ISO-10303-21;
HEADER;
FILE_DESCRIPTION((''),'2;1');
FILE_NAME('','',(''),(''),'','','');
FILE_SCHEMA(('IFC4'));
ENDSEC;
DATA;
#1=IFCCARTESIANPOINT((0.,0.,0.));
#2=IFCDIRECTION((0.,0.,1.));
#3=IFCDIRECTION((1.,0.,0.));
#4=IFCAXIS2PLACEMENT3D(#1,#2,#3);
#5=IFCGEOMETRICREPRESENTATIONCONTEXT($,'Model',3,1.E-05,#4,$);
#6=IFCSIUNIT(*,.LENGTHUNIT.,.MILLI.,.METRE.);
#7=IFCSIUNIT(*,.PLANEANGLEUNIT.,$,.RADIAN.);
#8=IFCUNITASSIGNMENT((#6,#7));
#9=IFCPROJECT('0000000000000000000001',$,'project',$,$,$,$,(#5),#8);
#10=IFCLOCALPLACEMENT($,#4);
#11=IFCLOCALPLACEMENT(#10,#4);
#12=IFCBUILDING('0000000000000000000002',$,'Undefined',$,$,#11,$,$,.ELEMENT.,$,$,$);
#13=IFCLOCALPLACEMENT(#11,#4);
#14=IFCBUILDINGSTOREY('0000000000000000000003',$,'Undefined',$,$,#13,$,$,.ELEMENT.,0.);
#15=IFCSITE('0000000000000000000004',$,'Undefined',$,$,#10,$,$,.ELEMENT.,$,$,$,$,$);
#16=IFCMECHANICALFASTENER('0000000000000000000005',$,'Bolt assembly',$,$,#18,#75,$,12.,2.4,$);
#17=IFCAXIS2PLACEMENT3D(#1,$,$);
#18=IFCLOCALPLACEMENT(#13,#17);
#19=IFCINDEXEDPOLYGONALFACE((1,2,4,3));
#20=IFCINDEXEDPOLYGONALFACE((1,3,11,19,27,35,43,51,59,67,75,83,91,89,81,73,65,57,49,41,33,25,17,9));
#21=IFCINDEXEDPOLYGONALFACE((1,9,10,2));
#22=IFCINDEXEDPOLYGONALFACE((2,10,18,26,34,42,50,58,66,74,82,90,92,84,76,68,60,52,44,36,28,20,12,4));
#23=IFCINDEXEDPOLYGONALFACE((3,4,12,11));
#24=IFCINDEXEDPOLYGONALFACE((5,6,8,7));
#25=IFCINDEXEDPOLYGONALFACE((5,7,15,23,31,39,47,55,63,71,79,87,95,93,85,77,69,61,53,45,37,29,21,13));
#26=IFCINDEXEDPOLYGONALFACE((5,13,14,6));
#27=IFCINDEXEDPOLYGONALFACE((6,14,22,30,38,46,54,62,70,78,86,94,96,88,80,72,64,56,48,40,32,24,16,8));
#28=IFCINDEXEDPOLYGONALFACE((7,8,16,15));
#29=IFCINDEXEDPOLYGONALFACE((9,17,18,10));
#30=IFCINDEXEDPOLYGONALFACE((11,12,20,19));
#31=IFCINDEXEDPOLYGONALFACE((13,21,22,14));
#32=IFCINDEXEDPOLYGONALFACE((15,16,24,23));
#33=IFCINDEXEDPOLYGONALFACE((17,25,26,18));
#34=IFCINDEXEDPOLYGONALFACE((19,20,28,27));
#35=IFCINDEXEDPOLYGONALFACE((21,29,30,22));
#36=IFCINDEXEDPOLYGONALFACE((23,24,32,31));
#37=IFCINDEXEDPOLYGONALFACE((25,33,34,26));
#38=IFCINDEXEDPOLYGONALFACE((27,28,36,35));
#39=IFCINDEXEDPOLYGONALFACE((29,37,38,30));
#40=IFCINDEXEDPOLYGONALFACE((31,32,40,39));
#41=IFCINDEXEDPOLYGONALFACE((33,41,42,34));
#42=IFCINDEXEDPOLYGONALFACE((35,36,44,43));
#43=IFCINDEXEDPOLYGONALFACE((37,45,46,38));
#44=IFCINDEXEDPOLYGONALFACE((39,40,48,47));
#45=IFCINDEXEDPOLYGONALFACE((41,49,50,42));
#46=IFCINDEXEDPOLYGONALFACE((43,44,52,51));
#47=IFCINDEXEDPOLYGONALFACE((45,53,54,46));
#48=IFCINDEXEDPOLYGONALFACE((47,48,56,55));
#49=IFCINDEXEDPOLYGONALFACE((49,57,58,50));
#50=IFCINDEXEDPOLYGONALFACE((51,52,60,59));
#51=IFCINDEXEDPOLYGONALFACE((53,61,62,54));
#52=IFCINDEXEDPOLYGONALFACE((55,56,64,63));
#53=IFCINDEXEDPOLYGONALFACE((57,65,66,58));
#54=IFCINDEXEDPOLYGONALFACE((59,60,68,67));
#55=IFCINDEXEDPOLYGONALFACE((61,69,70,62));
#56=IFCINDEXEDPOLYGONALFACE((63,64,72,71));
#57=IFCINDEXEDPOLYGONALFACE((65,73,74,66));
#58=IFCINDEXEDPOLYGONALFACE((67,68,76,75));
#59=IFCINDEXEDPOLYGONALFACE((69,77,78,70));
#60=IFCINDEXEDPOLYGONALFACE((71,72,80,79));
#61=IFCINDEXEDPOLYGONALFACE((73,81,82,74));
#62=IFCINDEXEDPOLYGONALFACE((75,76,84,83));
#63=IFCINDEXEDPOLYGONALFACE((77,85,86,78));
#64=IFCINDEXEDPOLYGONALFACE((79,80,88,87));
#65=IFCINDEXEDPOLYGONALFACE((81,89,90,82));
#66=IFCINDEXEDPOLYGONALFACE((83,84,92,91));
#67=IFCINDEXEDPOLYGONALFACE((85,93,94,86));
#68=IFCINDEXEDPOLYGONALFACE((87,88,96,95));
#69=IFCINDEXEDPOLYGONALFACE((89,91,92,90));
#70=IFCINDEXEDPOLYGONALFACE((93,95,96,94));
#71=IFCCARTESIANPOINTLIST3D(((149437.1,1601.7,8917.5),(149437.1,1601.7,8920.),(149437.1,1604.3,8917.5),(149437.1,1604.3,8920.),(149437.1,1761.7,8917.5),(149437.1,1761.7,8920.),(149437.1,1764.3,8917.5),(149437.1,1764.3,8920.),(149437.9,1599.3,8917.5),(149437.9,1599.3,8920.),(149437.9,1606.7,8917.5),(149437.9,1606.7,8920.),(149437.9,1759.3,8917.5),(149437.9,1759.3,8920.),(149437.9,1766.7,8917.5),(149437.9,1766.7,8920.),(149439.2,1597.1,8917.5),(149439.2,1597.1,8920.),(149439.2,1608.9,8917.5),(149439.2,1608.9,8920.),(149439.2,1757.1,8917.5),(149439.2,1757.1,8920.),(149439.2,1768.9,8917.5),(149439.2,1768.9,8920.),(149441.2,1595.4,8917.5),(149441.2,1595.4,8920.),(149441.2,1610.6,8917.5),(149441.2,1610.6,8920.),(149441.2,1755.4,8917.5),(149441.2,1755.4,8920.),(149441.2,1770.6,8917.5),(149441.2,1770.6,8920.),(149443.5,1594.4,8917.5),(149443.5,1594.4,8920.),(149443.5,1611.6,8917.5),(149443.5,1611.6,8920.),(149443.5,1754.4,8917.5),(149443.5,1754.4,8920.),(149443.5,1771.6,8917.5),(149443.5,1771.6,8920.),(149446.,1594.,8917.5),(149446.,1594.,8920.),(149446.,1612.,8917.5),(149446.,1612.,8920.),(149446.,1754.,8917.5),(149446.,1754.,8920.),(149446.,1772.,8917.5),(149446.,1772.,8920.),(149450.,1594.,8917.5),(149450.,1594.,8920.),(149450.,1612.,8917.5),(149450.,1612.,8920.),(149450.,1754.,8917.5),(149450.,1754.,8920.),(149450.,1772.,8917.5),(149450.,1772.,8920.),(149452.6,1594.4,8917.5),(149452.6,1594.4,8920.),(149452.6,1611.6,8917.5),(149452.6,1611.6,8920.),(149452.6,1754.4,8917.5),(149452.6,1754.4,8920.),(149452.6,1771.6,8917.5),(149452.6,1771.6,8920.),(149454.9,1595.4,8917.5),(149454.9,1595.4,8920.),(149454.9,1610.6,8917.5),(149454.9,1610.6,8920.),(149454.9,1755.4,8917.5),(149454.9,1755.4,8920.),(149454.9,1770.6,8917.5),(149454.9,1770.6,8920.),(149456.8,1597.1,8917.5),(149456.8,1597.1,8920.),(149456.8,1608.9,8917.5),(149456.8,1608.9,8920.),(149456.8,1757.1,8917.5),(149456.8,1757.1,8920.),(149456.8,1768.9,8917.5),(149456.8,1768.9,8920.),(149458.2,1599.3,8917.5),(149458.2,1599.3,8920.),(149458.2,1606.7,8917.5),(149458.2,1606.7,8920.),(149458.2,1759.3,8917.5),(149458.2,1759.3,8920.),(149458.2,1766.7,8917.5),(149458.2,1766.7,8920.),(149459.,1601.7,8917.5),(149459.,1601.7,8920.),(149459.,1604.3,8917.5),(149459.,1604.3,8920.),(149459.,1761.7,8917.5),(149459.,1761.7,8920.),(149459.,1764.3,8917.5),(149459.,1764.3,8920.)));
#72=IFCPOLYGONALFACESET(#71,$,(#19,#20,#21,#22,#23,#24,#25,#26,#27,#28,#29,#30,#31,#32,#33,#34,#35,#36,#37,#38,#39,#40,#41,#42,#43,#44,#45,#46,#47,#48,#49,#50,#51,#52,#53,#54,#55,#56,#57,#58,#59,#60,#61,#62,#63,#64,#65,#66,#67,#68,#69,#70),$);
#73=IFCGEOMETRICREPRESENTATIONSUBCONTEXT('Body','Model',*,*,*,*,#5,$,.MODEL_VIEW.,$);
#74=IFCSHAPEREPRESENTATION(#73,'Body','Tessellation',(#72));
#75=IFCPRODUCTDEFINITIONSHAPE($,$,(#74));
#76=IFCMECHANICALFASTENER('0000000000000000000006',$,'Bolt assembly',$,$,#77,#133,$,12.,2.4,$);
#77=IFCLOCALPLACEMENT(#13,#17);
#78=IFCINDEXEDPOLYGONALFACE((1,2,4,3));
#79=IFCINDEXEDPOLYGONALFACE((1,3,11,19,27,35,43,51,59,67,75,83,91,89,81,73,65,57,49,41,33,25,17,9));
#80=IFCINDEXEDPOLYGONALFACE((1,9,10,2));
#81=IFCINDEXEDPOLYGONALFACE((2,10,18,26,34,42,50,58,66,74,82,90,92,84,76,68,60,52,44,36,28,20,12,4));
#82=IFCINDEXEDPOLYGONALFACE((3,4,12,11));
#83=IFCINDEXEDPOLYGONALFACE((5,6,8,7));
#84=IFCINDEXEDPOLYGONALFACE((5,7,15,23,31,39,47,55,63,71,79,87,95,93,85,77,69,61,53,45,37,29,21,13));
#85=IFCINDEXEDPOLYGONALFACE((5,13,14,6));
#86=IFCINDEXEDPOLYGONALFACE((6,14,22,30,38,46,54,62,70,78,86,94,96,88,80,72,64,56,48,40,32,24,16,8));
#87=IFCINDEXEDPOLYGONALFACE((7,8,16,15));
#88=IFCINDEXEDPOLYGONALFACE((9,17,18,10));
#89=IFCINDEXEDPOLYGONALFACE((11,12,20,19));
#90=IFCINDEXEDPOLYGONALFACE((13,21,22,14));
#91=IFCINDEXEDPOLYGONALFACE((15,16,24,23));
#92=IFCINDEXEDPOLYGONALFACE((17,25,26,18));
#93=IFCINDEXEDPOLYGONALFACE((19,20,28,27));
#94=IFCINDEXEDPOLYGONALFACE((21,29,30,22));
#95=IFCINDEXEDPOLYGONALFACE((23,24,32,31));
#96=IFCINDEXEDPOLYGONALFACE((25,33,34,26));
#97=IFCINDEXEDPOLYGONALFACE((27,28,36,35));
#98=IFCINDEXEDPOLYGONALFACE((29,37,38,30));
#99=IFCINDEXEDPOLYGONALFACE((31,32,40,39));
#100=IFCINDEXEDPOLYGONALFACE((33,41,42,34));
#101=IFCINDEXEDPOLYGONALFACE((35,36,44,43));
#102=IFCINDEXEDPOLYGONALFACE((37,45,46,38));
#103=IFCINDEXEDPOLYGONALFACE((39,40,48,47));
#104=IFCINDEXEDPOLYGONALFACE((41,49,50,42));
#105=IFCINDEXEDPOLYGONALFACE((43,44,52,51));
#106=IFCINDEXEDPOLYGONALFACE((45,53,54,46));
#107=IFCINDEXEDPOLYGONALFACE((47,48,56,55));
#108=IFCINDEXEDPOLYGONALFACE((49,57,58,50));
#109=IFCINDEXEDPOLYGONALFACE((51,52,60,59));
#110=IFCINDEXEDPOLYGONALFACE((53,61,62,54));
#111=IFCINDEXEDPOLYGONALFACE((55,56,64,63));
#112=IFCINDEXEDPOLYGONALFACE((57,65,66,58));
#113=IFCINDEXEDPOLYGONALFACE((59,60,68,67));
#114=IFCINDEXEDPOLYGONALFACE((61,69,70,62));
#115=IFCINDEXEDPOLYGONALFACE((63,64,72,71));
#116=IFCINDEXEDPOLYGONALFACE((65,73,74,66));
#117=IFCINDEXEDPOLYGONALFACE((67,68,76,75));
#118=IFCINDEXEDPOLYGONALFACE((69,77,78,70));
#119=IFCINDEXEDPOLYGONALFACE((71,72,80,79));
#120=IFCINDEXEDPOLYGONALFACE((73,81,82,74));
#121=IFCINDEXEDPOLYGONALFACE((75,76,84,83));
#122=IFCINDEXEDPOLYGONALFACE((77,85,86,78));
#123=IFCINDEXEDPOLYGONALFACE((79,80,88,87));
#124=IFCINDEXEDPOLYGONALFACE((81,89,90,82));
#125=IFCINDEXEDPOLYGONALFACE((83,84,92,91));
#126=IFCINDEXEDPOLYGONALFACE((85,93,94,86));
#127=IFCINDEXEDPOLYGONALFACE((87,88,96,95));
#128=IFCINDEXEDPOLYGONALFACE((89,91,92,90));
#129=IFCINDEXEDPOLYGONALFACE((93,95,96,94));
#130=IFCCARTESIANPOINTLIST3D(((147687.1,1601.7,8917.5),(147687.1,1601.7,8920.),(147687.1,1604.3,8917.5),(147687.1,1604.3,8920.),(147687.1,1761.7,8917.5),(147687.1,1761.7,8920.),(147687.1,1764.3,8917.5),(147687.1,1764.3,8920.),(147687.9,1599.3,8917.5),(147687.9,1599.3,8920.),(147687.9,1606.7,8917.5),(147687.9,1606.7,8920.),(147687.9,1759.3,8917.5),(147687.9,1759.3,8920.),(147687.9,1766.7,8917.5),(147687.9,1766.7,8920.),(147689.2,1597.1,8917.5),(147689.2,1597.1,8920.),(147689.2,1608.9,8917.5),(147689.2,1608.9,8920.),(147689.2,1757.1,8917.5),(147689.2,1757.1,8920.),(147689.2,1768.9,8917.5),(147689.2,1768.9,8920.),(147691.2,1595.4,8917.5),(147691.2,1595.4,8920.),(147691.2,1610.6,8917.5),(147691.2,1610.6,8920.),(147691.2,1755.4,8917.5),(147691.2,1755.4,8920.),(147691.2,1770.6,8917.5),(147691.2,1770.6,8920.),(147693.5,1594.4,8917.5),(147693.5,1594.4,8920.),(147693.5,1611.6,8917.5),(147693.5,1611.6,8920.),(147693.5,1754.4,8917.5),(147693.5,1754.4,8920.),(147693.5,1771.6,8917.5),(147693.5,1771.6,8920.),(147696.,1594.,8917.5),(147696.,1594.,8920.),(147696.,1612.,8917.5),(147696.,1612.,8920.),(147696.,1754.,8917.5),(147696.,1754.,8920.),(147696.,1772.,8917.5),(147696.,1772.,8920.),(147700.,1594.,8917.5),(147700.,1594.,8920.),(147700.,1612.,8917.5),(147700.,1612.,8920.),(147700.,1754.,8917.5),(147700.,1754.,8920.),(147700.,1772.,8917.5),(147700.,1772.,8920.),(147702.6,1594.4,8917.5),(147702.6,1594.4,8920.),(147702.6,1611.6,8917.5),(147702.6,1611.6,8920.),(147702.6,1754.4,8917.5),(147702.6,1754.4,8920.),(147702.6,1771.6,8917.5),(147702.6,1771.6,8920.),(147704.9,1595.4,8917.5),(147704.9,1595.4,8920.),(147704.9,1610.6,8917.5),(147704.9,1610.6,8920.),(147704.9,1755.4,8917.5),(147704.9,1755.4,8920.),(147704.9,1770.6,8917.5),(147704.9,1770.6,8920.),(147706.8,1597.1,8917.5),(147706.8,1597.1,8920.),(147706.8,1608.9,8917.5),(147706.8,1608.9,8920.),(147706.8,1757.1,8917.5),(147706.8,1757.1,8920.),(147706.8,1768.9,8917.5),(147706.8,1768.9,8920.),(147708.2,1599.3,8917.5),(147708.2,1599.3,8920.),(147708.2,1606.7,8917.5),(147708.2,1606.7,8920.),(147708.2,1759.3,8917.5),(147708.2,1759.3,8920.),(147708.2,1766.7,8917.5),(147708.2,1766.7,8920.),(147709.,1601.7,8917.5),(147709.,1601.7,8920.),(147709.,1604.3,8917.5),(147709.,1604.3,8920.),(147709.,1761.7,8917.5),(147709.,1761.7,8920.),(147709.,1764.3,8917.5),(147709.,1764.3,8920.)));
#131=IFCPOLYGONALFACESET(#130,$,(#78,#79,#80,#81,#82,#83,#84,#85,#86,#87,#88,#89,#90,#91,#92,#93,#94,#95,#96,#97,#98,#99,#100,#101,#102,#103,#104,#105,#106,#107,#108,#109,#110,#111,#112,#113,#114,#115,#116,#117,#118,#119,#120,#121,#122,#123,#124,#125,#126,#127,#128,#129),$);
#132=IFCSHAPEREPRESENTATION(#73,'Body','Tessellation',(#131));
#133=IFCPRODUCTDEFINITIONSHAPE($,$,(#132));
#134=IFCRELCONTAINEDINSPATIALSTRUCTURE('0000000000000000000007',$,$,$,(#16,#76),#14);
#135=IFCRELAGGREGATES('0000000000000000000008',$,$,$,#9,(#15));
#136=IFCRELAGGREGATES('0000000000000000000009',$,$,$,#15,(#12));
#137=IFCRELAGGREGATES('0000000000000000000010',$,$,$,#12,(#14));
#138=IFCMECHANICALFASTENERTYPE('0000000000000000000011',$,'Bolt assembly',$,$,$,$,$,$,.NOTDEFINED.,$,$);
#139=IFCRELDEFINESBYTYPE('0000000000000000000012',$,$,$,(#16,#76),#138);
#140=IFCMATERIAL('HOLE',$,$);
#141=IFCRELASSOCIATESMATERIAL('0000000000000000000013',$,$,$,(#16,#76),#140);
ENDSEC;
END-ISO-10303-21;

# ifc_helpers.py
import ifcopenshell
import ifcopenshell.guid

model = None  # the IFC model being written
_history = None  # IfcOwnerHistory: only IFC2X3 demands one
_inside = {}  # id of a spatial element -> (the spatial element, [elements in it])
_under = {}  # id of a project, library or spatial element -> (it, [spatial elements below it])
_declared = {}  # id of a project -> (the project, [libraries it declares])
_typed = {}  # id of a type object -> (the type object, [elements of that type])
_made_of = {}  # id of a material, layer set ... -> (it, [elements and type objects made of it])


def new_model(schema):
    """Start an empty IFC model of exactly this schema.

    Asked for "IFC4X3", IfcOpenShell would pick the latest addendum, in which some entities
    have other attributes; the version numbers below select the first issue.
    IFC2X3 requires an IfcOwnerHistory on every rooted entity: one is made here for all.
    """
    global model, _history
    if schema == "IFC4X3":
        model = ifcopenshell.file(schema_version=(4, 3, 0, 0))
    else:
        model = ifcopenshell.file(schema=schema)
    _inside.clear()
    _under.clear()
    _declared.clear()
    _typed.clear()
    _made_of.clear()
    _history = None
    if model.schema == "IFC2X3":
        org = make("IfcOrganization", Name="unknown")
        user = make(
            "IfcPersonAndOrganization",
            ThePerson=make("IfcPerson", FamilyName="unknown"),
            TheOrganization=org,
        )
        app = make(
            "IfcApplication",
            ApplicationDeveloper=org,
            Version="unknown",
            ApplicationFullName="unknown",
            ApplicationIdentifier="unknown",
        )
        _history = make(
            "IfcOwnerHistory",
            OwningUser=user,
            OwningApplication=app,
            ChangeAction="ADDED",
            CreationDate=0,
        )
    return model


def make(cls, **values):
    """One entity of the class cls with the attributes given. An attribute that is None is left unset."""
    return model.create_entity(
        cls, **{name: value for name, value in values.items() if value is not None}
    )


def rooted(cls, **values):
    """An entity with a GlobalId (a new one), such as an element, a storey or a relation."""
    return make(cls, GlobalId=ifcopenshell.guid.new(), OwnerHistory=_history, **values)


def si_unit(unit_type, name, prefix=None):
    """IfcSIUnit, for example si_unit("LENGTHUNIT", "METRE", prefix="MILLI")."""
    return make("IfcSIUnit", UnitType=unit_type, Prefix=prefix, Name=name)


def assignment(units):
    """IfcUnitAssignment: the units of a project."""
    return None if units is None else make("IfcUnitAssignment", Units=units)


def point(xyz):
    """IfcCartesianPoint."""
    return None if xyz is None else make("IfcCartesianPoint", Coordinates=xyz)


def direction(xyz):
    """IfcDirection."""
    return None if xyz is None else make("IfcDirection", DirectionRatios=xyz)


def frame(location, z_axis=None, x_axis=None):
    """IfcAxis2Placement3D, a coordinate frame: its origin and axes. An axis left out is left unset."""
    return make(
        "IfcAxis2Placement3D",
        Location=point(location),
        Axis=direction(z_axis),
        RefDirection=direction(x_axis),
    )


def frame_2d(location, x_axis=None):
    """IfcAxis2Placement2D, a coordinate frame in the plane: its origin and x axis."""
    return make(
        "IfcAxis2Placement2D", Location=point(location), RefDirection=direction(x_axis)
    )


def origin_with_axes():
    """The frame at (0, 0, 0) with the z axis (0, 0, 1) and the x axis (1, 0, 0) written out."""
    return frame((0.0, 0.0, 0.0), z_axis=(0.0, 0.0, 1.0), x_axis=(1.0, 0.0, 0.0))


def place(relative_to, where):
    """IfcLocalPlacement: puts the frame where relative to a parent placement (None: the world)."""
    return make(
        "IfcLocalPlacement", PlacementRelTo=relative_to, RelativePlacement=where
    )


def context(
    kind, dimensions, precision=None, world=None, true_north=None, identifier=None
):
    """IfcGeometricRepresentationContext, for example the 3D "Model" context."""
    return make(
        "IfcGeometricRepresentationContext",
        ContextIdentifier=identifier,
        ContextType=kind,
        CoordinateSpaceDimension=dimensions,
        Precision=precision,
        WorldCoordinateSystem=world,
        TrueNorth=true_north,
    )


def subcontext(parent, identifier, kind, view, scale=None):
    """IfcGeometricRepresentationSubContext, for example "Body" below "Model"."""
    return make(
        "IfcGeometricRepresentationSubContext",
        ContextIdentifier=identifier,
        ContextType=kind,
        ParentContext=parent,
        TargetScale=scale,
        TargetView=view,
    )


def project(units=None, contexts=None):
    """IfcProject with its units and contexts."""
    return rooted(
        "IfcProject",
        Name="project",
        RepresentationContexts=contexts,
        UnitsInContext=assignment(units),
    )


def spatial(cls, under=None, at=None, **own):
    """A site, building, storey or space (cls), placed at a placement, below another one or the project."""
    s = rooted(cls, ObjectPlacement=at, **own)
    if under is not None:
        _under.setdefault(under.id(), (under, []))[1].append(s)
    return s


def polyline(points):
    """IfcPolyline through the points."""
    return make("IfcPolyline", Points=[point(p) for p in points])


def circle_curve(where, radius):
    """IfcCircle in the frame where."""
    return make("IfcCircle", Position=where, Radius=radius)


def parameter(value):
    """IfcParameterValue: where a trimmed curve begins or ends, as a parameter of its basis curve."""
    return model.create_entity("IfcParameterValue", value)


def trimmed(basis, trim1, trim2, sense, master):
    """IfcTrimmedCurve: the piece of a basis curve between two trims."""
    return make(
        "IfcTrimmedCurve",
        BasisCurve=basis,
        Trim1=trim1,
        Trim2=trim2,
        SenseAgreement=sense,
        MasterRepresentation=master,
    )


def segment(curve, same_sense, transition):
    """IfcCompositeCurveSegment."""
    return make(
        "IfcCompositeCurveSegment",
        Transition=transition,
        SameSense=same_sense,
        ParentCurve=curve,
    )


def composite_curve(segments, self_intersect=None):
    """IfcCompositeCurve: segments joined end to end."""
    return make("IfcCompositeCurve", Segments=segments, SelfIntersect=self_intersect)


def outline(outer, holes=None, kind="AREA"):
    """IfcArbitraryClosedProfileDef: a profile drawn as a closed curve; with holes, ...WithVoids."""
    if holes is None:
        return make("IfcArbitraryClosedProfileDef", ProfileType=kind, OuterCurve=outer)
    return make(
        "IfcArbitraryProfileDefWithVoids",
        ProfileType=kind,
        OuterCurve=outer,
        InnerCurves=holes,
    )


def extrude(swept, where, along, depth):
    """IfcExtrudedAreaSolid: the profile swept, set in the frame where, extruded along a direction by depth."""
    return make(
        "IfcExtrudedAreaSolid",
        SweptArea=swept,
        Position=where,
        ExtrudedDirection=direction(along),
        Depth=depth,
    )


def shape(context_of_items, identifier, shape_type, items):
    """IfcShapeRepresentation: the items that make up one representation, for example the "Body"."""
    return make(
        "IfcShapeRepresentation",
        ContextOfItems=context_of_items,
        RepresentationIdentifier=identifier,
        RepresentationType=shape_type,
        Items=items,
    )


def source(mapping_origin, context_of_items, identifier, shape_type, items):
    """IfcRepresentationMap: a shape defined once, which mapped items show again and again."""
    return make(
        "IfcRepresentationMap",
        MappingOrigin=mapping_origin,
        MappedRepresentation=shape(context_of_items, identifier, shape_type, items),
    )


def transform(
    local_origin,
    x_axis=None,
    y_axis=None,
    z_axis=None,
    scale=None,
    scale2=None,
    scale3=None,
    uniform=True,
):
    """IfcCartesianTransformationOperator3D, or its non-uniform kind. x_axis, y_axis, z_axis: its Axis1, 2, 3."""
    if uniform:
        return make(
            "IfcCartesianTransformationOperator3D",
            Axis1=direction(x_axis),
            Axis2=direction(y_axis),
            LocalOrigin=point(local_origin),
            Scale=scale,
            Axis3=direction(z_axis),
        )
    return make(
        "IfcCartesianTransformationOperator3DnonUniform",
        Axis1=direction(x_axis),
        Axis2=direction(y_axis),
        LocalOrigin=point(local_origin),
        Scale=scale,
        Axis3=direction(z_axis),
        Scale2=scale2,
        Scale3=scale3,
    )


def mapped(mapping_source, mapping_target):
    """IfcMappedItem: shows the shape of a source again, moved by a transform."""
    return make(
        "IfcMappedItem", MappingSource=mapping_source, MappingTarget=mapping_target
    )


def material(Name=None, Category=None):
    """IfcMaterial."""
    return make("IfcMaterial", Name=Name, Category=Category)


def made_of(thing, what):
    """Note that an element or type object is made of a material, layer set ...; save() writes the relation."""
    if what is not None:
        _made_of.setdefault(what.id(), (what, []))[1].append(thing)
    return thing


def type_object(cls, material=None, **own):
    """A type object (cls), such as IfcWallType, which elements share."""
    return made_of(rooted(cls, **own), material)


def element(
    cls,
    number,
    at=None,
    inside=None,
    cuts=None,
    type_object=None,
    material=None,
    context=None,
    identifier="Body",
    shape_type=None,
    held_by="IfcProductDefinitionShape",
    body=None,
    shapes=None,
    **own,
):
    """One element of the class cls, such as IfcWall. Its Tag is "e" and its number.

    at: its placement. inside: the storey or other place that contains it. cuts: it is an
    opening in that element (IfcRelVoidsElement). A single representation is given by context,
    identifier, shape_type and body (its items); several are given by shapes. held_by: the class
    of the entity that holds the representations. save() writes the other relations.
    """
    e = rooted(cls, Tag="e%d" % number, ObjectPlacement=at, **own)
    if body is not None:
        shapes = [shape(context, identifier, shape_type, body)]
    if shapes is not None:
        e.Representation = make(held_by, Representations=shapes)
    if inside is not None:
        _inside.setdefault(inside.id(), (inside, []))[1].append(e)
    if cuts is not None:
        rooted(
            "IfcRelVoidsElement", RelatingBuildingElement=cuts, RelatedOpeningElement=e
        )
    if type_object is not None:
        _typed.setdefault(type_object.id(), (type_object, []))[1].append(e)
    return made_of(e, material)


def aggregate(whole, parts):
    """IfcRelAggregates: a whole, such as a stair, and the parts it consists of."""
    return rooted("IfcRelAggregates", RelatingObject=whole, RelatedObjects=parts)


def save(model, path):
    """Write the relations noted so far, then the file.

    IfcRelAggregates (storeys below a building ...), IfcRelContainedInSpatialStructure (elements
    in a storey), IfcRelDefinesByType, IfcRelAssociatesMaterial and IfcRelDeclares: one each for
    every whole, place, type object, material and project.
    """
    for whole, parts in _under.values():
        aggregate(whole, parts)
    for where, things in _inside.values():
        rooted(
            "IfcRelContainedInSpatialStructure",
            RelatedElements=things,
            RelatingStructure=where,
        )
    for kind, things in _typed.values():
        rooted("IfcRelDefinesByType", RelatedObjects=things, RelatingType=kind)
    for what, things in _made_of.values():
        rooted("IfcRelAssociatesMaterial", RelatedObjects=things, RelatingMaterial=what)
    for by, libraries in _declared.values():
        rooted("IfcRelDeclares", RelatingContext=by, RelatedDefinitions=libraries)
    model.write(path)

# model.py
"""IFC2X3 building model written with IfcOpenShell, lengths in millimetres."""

from ifc_helpers import new_model, si_unit, frame, frame_2d, origin_with_axes, place, context, subcontext, project, spatial, polyline, circle_curve, parameter, trimmed, segment, composite_curve, outline, extrude, source, transform, mapped, material, type_object, element, save


model = new_model("IFC2X3")

# Units and contexts
model_context = context("Model", 3, precision=1e-05, world=origin_with_axes())
body_context = subcontext(model_context, "Body", "Model", "MODEL_VIEW")
ifc_project = project(units=[si_unit("LENGTHUNIT", "METRE", prefix="MILLI"), si_unit("PLANEANGLEUNIT", "RADIAN")], contexts=[model_context])

# Site, building, storey
site_placement = place(None, origin_with_axes())
site = spatial("IfcSite", under=ifc_project, at=site_placement, Name="Undefined", CompositionType="ELEMENT")
building_placement = place(site_placement, origin_with_axes())
building = spatial("IfcBuilding", under=site, at=building_placement, Name="Undefined", CompositionType="ELEMENT")
storey_placement = place(building_placement, origin_with_axes())
storey = spatial("IfcBuildingStorey", under=building, at=storey_placement, Name="Undefined", CompositionType="ELEMENT", Elevation=0.0)

# Mechanical fasteners
mechanical_fastener_type = type_object("IfcMechanicalFastenerType", Name="Bolt assembly")
ifc_material_1 = material(Name="HOLE")
shared_shape_1 = source(origin_with_axes(), body_context, "Body", "SweptSolid", [
    extrude(outline(composite_curve([segment(polyline([(-2.0, 9.0), (2.0, 9.0)]), True, "CONTINUOUS"), segment(trimmed(circle_curve(frame_2d((2.0, 0.0), x_axis=(0.0, 1.0)), 9.0), [parameter(0.0)], [parameter(3.141593)], False, "PARAMETER"), True, "CONTINUOUS"), segment(polyline([(2.0, -9.0), (-2.0, -9.0)]), True, "CONTINUOUS"), segment(trimmed(circle_curve(frame_2d((-2.0, 0.0), x_axis=(0.0, -1.0)), 9.0), [parameter(0.0)], [parameter(3.141593)], False, "PARAMETER"), True, "DISCONTINUOUS")], self_intersect=False)), frame((0.0, -2.4, 0.0), z_axis=(0.0, 1.0, 0.0), x_axis=(1.0, 0.0, 0.0)), (0.0, 0.0, 1.0), 2.5),
])
mechanical_fastener_1_placement = place(storey_placement, frame((149448.0, 1683.0, 8917.6), z_axis=(0.0, -1.0, 0.0), x_axis=(-1.0, 0.0, 0.0)))
element("IfcMechanicalFastener", 1, at=mechanical_fastener_1_placement, inside=storey, type_object=mechanical_fastener_type, material=ifc_material_1, Name="Bolt assembly", NominalDiameter=12.0, NominalLength=2.4, context=body_context, shape_type="MappedRepresentation", body=[
    mapped(shared_shape_1, transform((0.0, 0.0, -80.0))),
    mapped(shared_shape_1, transform((0.0, 0.0, 80.0))),
])
shared_shape_2 = source(origin_with_axes(), body_context, "Body", "SweptSolid", [
    extrude(outline(composite_curve([segment(polyline([(-2.0, 9.0), (2.0, 9.0)]), True, "CONTINUOUS"), segment(trimmed(circle_curve(frame_2d((2.0, 0.0), x_axis=(0.0, 1.0)), 9.0), [parameter(0.0)], [parameter(3.141593)], False, "PARAMETER"), True, "CONTINUOUS"), segment(polyline([(2.0, -9.0), (-2.0, -9.0)]), True, "CONTINUOUS"), segment(trimmed(circle_curve(frame_2d((-2.0, 0.0), x_axis=(0.0, -1.0)), 9.0), [parameter(0.0)], [parameter(3.141593)], False, "PARAMETER"), True, "DISCONTINUOUS")], self_intersect=False)), frame((0.0, -2.4, 0.0), z_axis=(0.0, 1.0, 0.0), x_axis=(1.0, 0.0, 0.0)), (0.0, 0.0, 1.0), 2.5),
])
mechanical_fastener_2_placement = place(storey_placement, frame((147698.0, 1683.0, 8917.6), z_axis=(0.0, -1.0, 0.0), x_axis=(-1.0, 0.0, 0.0)))
element("IfcMechanicalFastener", 2, at=mechanical_fastener_2_placement, inside=storey, type_object=mechanical_fastener_type, material=ifc_material_1, Name="Bolt assembly", NominalDiameter=12.0, NominalLength=2.4, context=body_context, shape_type="MappedRepresentation", body=[
    mapped(shared_shape_2, transform((0.0, 0.0, -80.0))),
    mapped(shared_shape_2, transform((0.0, 0.0, 80.0))),
])

save(model, "model.ifc")
